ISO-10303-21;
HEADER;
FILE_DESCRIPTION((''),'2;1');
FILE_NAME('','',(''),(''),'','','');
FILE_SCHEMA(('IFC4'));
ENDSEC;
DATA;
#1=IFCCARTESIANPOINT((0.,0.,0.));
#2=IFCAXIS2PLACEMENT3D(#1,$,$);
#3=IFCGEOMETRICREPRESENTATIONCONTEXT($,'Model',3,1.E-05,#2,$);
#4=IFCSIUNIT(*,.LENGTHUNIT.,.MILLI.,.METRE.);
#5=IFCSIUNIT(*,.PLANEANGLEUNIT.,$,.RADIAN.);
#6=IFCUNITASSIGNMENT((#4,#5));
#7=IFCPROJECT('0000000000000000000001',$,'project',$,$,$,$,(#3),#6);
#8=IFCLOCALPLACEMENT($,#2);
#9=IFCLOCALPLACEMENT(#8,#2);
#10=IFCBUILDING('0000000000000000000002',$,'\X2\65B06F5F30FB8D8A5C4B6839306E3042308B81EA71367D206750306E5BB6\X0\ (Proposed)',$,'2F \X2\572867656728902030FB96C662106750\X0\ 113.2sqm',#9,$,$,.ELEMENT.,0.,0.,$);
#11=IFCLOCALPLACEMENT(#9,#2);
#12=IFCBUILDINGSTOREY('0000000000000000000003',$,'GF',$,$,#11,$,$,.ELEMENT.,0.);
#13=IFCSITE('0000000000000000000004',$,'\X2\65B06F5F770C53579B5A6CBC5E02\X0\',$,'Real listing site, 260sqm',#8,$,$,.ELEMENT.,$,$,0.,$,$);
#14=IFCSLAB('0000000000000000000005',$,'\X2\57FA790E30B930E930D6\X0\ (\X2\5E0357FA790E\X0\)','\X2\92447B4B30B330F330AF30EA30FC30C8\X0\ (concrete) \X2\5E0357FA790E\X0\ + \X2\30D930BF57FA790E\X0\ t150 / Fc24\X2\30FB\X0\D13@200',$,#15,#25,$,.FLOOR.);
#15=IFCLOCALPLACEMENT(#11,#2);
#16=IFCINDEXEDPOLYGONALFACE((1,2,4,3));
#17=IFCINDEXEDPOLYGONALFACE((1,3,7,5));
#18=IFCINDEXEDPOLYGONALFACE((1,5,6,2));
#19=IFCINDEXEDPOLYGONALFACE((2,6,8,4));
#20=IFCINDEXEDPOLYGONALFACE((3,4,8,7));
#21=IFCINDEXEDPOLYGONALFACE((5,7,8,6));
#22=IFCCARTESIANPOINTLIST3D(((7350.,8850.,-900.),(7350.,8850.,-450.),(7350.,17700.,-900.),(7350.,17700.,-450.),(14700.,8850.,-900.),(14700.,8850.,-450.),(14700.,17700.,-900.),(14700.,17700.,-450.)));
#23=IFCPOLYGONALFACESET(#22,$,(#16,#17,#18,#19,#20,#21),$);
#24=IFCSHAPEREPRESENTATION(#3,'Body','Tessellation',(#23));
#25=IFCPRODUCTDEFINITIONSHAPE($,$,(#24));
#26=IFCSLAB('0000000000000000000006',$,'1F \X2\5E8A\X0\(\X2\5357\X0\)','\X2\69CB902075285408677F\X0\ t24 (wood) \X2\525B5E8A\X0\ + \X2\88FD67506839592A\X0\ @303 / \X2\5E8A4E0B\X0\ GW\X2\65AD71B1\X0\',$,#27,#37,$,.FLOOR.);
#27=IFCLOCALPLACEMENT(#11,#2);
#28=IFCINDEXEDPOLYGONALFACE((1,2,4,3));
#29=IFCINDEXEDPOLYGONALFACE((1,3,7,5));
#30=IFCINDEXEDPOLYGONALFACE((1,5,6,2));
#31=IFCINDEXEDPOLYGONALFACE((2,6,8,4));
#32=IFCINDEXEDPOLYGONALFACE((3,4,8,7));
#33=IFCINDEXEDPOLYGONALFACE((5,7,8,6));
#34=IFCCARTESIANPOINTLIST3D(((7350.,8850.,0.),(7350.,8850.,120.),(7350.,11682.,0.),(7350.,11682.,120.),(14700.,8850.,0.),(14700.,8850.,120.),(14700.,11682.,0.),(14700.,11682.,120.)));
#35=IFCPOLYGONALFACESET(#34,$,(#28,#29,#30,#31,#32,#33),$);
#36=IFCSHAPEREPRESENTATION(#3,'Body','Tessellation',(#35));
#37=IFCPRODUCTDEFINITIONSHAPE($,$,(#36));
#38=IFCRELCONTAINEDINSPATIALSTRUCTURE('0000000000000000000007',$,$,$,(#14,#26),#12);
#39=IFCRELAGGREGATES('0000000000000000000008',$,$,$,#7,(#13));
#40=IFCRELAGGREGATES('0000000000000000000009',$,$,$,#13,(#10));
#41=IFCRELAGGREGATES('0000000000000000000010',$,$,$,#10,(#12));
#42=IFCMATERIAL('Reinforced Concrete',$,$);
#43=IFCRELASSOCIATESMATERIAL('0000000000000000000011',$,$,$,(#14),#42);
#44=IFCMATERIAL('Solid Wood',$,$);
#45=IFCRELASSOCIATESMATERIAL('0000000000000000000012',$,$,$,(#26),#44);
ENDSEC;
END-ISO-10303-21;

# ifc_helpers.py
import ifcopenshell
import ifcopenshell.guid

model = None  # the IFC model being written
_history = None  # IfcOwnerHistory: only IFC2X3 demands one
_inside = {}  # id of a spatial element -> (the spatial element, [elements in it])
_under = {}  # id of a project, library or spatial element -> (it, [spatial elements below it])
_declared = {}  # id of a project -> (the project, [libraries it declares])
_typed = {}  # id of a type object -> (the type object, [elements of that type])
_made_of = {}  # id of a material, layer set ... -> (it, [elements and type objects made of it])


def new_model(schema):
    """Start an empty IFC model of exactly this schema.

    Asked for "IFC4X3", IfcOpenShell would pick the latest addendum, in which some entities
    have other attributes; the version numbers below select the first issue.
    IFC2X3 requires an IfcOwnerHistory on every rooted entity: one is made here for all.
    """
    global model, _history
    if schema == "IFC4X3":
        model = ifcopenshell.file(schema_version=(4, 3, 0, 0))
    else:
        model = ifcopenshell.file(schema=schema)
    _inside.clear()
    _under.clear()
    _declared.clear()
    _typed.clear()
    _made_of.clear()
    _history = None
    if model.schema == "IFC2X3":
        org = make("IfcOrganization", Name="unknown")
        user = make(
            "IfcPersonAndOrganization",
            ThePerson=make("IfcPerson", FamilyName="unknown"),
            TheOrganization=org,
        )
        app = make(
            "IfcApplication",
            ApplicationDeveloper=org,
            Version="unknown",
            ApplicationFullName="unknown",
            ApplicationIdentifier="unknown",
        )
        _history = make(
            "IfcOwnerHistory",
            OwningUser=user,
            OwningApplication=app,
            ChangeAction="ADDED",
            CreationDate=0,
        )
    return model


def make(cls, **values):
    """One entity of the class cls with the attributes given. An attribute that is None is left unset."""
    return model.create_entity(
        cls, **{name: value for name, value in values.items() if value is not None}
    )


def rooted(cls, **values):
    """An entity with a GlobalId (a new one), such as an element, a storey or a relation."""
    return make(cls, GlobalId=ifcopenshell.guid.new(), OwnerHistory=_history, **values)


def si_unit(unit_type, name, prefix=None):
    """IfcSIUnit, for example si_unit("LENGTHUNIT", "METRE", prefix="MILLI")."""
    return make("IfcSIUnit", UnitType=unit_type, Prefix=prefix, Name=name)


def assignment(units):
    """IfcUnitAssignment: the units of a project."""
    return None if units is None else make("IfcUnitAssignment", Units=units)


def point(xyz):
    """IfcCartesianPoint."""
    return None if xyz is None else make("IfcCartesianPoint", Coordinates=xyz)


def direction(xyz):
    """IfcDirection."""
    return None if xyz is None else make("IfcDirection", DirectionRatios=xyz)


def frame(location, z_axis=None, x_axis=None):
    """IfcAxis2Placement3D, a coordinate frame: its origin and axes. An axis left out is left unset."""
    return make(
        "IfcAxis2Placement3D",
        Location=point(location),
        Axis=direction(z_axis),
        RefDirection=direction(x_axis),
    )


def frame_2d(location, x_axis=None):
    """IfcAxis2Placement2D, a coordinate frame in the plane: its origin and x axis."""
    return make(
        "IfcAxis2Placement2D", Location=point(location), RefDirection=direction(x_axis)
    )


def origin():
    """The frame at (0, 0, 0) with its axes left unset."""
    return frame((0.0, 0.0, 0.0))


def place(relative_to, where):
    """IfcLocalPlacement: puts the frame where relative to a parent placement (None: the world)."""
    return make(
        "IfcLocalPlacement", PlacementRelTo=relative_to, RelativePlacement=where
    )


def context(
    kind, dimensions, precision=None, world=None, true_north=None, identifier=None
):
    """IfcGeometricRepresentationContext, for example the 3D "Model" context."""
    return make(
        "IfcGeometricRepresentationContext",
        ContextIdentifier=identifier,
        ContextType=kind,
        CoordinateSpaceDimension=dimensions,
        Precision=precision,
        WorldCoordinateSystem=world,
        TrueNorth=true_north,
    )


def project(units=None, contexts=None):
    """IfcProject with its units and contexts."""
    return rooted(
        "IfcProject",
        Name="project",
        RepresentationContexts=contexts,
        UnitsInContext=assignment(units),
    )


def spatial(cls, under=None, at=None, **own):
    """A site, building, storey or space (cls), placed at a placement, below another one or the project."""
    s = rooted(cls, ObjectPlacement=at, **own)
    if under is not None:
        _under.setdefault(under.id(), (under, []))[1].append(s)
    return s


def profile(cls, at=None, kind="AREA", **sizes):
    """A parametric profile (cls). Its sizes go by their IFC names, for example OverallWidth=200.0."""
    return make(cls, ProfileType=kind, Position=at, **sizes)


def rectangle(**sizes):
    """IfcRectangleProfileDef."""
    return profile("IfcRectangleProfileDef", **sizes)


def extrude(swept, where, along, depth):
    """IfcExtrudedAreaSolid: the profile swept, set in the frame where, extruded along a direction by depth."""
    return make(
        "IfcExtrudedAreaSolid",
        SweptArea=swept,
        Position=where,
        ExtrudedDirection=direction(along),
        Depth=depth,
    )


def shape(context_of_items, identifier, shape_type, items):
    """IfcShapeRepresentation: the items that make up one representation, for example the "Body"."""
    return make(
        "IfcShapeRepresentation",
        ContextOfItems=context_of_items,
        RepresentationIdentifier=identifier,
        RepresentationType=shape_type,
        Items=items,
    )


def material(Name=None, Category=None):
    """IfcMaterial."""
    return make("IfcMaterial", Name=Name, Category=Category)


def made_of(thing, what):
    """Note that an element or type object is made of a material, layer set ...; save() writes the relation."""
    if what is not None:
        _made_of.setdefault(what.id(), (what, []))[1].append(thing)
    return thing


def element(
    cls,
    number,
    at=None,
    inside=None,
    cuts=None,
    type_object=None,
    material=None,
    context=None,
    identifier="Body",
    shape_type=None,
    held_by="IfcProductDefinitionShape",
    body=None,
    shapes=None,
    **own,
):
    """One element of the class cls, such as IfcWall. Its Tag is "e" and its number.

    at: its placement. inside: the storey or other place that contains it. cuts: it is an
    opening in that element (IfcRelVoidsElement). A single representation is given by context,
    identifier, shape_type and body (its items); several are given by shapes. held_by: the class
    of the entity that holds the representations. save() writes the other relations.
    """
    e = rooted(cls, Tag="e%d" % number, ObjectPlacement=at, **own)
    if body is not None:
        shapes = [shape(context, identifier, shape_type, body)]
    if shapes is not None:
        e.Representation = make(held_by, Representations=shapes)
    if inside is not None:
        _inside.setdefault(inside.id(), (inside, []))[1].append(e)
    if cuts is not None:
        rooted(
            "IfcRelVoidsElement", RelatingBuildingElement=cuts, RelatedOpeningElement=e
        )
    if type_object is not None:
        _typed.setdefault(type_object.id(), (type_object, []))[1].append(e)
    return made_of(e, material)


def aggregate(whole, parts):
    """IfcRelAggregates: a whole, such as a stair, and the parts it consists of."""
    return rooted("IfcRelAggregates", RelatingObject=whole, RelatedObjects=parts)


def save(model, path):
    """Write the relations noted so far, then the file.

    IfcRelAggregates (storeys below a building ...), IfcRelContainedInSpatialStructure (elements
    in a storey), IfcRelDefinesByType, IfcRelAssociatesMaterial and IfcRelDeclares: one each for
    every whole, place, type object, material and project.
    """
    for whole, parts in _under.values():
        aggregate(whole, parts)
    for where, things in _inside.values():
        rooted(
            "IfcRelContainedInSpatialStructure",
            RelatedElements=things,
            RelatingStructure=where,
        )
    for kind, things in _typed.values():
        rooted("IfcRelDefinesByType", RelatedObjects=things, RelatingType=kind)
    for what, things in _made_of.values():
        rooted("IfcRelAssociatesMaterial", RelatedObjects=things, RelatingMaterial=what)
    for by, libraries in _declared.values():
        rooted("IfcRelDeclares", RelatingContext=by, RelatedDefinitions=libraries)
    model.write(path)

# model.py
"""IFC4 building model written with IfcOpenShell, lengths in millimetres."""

from ifc_helpers import new_model, si_unit, frame, frame_2d, origin, place, context, project, spatial, rectangle, extrude, material, element, save


model = new_model("IFC4")

# Units and contexts
model_context = context("Model", 3, precision=1e-05, world=origin())
ifc_project = project(units=[si_unit("LENGTHUNIT", "METRE", prefix="MILLI"), si_unit("PLANEANGLEUNIT", "RADIAN")], contexts=[model_context])

# Site, building, storey
site_placement = place(None, origin())
site = spatial("IfcSite", under=ifc_project, at=site_placement, Name="新潟県南魚沼市", ObjectType="Real listing site, 260sqm", CompositionType="ELEMENT", RefElevation=0.0)
building_placement = place(site_placement, origin())
building = spatial("IfcBuilding", under=site, at=building_placement, Name="新潟・越屋根のある自然素材の家 (Proposed)", ObjectType="2F 在来木造・集成材 113.2sqm", CompositionType="ELEMENT", ElevationOfRefHeight=0.0, ElevationOfTerrain=0.0)
storey_placement = place(building_placement, origin())
storey = spatial("IfcBuildingStorey", under=building, at=storey_placement, Name="GF", CompositionType="ELEMENT", Elevation=0.0)

# Shared definitions
ifc_material_1 = material(Name="Solid Wood")

# Slabs
ifc_material_2 = material(Name="Reinforced Concrete")
slab_1_placement = place(storey_placement, frame((3675.0, 4425.0, -450.0)))
element("IfcSlab", 1, at=slab_1_placement, inside=storey, material=ifc_material_2, Name="基礎スラブ (布基礎)", Description="鉄筋コンクリート (concrete) 布基礎 + ベタ基礎 t150 / Fc24・D13@200", PredefinedType="FLOOR", context=model_context, shape_type="SweptSolid", body=[
    extrude(rectangle(XDim=7350.0, YDim=8850.0, at=frame_2d((3675.0, 4425.0))), frame((3675.0, 4425.0, -450.0)), (0.0, 0.0, 1.0), 450.0),
])
slab_2_placement = place(storey_placement, frame((3675.0, 4425.0, 0.0)))
element("IfcSlab", 2, at=slab_2_placement, inside=storey, material=ifc_material_1, Name="1F 床(南)", Description="構造用合板 t24 (wood) 剛床 + 製材根太 @303 / 床下 GW断熱", PredefinedType="FLOOR", context=model_context, shape_type="SweptSolid", body=[
    extrude(rectangle(XDim=7350.0, YDim=2832.0, at=frame_2d((3675.0, 1416.0))), frame((3675.0, 4425.0, 0.0)), (0.0, 0.0, 1.0), 120.0),
])

save(model, "model.ifc")
